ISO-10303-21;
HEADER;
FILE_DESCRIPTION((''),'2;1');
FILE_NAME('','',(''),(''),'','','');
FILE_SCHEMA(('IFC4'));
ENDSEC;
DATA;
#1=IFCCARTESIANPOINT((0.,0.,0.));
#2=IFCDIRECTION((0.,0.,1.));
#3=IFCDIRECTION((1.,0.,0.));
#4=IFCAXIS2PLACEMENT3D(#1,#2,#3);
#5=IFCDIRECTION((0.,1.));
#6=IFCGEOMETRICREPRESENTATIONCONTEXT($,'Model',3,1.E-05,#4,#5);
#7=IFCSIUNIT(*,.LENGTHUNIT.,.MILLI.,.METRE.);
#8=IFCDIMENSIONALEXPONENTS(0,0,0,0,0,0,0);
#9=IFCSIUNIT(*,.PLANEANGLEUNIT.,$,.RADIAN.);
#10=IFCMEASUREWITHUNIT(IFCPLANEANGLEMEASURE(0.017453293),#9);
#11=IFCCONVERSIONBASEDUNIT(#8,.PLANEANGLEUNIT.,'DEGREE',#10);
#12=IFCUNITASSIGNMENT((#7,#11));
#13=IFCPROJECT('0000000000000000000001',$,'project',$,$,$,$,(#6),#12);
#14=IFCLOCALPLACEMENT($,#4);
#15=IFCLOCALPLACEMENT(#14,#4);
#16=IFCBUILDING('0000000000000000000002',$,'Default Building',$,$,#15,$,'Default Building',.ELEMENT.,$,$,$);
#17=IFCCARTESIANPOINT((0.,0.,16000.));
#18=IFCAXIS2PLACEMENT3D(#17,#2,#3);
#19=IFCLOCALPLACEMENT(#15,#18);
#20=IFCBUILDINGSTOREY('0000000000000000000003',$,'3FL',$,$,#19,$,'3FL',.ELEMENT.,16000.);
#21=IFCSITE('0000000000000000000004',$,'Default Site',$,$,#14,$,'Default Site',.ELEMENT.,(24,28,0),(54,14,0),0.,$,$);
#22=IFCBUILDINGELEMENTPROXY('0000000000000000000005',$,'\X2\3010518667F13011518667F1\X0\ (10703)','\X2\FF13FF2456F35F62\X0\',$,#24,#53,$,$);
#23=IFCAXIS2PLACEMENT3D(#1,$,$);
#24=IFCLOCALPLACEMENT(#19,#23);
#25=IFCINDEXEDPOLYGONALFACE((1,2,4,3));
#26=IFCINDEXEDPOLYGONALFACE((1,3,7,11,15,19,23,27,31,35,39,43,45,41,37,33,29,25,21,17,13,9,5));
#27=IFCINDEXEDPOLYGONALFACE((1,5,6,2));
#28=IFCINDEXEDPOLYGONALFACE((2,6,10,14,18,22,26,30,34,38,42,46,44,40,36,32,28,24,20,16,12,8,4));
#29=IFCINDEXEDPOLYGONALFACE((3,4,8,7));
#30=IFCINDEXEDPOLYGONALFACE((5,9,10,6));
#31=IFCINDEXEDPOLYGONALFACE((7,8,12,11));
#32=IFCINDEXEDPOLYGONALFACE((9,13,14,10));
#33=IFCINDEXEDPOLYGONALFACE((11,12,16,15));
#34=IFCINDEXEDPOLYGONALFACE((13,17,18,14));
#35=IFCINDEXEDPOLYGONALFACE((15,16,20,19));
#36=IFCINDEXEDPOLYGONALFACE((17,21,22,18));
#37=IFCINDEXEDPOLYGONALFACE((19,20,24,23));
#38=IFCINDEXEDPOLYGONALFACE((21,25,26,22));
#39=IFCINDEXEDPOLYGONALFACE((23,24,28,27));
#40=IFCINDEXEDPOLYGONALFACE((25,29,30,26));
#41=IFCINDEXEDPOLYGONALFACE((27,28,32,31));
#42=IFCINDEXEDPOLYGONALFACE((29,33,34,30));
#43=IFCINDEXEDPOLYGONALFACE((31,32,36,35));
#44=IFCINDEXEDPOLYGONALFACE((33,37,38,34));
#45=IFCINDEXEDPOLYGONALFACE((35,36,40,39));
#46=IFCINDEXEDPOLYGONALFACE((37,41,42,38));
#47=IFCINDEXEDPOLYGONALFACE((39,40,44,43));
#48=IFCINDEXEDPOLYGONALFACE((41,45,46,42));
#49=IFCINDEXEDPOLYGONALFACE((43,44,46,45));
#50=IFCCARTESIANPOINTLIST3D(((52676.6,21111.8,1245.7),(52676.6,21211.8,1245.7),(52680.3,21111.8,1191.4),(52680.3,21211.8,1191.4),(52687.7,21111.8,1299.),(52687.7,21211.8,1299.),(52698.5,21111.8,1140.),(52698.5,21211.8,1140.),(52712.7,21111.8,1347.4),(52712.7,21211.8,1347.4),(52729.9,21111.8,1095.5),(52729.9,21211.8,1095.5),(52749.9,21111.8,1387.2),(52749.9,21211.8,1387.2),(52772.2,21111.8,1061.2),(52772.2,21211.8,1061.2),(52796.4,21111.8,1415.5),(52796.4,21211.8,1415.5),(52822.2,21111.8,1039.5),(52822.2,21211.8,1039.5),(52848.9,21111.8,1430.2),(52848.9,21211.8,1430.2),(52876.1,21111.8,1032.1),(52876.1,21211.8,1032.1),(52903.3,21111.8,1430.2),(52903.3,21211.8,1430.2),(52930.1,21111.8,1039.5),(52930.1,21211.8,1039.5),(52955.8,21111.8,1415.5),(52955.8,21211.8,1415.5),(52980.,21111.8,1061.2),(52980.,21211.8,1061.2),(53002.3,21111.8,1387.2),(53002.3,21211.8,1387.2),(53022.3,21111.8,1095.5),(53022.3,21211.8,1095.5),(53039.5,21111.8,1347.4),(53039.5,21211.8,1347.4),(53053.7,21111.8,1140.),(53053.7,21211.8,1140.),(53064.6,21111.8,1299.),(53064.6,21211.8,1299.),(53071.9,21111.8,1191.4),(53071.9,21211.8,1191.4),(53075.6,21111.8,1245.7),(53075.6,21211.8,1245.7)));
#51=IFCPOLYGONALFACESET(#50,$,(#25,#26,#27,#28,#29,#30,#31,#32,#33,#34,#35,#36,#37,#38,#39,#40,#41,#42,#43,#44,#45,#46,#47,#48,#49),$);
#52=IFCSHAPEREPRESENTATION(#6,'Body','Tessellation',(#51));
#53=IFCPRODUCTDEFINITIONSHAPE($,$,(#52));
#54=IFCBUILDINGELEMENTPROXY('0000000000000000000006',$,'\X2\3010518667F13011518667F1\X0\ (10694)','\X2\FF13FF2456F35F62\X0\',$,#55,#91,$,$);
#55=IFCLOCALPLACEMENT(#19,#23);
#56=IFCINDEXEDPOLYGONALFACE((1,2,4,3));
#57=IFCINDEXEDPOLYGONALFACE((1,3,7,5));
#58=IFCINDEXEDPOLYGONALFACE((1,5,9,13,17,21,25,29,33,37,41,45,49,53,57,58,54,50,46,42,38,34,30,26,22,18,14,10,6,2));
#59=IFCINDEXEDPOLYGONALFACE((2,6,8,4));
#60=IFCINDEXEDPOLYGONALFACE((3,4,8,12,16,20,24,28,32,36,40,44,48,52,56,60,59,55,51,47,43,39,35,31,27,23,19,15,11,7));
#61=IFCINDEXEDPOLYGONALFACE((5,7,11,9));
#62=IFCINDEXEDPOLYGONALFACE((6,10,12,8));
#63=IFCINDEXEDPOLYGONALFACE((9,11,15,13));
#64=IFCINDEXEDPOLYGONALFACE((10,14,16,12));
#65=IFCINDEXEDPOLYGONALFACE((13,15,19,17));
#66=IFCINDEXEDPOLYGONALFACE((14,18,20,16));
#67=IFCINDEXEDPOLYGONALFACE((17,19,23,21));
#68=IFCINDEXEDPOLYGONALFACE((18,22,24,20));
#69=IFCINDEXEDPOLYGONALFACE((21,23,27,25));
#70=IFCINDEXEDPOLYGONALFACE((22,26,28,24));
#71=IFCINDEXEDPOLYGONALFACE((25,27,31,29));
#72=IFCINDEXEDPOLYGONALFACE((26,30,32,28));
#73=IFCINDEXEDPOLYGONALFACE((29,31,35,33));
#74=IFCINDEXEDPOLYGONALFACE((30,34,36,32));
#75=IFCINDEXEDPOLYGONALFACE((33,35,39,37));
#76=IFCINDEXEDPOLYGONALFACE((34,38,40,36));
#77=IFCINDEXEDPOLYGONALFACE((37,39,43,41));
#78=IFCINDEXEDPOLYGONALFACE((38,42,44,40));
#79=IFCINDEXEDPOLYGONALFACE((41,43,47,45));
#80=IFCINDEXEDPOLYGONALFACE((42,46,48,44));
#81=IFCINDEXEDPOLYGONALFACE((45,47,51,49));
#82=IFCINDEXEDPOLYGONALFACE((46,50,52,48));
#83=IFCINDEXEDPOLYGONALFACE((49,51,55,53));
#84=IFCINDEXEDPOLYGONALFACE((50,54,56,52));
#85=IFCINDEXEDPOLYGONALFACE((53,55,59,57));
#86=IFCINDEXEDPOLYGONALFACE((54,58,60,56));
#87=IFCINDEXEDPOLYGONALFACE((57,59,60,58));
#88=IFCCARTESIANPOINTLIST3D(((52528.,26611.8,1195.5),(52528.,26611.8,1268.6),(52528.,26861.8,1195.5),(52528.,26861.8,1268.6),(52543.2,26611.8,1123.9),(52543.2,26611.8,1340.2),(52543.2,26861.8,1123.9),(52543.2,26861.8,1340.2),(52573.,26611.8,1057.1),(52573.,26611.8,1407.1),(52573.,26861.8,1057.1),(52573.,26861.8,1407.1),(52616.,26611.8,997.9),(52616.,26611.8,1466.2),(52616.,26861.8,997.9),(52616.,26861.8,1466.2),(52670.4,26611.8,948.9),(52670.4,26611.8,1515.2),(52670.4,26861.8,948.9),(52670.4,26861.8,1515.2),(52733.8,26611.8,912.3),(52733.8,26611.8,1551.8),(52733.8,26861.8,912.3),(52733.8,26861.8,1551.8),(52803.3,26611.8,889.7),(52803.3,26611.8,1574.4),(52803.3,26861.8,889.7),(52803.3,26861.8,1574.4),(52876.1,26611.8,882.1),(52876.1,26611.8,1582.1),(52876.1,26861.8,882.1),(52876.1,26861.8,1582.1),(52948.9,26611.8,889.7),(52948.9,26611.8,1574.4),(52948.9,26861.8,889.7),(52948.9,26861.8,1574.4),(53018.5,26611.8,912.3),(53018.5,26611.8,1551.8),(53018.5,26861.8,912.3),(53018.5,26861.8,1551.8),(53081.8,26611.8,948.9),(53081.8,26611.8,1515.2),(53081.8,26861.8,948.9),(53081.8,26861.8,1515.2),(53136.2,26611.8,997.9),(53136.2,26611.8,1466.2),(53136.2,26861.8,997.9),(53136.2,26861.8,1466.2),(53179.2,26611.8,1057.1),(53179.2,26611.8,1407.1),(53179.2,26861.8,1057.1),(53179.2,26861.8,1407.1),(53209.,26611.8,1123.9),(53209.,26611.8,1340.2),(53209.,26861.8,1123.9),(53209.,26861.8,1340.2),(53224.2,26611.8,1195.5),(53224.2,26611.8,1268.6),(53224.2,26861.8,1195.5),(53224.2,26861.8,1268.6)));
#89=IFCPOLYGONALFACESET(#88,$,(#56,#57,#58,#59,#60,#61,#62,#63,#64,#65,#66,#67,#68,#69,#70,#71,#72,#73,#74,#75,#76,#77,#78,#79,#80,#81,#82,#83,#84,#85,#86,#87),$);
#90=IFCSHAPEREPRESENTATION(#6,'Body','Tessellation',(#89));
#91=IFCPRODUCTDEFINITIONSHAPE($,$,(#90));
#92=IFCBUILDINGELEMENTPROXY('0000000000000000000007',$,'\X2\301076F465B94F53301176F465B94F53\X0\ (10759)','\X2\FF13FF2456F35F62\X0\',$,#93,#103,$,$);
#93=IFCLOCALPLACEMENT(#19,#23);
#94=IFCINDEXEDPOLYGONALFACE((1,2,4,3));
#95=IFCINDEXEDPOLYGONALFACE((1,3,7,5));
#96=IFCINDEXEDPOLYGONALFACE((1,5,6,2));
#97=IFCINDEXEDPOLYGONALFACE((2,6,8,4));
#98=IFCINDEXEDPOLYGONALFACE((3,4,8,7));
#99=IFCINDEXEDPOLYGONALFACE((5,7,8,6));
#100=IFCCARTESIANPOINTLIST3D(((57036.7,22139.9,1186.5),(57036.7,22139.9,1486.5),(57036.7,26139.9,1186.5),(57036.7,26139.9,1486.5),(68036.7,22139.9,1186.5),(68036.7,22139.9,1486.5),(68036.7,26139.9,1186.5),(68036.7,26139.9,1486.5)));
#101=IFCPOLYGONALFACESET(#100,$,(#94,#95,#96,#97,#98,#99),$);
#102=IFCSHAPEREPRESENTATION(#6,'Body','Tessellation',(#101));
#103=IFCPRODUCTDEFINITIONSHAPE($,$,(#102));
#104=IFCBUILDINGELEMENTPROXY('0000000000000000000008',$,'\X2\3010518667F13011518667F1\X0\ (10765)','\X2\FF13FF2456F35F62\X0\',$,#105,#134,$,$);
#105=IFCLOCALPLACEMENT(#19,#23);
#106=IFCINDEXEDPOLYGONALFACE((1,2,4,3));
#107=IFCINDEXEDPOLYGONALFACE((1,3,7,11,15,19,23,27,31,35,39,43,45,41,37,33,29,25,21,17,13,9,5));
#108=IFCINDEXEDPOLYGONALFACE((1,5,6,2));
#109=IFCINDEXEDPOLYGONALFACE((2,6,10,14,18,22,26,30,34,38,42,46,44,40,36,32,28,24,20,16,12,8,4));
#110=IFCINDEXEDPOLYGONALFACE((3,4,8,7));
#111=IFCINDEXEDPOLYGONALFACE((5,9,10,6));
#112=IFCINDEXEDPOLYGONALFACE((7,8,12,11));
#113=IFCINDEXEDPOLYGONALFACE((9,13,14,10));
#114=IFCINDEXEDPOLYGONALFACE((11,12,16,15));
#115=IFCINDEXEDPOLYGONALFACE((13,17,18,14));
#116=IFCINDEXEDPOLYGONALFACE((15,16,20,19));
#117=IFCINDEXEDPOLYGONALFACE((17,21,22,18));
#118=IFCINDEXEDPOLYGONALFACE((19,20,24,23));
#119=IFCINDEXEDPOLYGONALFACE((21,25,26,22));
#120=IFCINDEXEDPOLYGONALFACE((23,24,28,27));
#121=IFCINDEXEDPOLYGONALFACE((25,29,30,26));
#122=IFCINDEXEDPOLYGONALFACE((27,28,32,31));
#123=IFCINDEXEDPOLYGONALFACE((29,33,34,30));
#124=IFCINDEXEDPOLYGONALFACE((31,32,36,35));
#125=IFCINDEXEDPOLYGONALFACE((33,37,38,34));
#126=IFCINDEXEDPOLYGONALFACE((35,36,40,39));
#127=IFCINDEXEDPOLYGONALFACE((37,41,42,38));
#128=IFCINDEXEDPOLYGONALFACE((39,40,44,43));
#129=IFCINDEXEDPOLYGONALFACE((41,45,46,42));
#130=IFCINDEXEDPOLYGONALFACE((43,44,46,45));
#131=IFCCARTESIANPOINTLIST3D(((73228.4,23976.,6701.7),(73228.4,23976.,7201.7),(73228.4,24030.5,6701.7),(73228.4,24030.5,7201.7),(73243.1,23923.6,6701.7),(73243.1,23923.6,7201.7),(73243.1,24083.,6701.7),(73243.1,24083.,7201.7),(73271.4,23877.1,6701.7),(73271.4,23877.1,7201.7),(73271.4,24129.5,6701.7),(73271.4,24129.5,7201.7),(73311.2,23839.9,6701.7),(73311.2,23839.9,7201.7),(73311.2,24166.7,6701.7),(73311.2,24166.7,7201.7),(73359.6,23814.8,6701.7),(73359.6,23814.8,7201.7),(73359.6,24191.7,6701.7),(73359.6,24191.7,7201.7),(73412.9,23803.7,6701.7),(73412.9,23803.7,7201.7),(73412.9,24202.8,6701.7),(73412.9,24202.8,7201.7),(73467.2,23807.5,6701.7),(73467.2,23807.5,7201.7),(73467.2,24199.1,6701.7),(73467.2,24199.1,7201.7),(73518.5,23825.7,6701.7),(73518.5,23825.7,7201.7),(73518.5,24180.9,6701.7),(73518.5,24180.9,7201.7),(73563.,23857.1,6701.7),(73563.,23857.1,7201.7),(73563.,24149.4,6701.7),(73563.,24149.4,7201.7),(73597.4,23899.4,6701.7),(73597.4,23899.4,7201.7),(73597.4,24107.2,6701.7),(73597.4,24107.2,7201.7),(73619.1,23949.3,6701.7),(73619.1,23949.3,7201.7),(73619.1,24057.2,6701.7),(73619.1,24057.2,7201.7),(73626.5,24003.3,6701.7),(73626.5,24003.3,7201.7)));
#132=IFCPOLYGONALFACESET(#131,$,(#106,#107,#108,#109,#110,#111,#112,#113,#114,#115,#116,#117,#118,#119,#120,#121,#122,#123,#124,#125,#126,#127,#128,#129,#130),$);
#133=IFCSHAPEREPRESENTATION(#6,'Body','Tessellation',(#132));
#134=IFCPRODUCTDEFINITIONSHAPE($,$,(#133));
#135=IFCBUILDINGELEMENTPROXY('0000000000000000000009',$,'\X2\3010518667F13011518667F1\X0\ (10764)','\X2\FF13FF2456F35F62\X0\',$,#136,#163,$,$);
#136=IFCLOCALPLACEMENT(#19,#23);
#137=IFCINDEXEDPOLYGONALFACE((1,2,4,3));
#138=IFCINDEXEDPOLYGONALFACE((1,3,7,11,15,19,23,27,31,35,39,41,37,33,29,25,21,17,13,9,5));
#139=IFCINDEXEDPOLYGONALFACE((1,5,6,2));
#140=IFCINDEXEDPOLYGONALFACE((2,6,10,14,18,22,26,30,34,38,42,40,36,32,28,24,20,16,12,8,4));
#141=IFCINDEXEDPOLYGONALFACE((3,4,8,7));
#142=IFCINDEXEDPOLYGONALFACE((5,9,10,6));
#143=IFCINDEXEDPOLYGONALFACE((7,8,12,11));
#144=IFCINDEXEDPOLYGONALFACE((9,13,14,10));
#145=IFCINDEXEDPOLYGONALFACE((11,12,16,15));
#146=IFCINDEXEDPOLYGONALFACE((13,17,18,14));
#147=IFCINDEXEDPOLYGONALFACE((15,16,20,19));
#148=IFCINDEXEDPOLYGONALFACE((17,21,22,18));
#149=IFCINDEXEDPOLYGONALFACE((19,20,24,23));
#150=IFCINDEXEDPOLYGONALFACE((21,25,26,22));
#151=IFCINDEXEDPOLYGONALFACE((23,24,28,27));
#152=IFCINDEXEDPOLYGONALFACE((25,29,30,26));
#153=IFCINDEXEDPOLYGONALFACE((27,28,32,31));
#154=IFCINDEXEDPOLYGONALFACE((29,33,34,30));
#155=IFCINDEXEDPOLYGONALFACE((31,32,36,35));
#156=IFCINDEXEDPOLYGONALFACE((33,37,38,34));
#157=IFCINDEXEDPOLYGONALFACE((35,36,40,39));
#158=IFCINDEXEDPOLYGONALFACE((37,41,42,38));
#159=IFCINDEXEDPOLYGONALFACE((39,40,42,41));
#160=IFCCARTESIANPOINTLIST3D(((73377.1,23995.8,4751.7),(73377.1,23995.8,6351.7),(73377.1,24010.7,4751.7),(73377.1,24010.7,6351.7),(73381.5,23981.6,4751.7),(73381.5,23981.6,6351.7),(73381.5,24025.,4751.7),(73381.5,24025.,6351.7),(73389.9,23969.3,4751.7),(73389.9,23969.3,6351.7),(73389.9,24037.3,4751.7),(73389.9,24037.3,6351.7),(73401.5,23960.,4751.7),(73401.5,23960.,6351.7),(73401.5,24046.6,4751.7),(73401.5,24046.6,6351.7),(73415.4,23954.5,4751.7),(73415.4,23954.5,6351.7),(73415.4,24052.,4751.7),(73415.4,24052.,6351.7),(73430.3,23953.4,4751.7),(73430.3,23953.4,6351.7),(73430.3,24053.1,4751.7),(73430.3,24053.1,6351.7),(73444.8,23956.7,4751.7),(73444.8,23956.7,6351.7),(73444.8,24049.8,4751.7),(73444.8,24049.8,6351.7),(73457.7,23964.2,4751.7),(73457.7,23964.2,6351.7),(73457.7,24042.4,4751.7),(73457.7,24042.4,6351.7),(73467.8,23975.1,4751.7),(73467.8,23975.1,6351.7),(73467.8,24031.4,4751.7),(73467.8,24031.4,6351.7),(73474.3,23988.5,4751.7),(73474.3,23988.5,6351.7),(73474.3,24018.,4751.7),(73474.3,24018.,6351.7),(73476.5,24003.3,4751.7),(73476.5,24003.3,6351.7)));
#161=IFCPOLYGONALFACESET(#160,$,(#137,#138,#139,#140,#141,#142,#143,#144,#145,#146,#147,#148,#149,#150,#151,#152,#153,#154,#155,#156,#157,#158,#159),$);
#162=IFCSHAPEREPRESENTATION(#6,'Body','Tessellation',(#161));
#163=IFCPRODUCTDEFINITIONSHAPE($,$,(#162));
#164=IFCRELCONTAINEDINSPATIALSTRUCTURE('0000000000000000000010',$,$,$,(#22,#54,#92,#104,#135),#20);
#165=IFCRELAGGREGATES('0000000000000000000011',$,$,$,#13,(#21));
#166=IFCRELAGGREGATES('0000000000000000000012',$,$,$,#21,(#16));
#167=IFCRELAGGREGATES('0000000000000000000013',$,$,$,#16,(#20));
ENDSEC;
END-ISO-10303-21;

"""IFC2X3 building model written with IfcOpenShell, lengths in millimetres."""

from ifc_helpers import new_model, entity, si_unit, converted_unit, direction, frame, origin_with_axes, origin_2d_with_axis, place, context, project, spatial, rectangle, circle, extrude, source, transform, mapped, element, save


model = new_model("IFC2X3")

# Units and contexts
model_context = context("Model", 3, precision=1e-05, world=origin_with_axes(), true_north=direction((0.0, 1.0)))
ifc_project = project(units=[si_unit("LENGTHUNIT", "METRE", prefix="MILLI"), converted_unit("PLANEANGLEUNIT", "DEGREE", entity("IfcPlaneAngleMeasure", 0.017453293), si_unit("PLANEANGLEUNIT", "RADIAN"), dimensions=[0, 0, 0, 0, 0, 0, 0])], contexts=[model_context])

# Site, building, storey
site_placement = place(None, origin_with_axes())
site = spatial("IfcSite", under=ifc_project, at=site_placement, Name="Default Site", LongName="Default Site", CompositionType="ELEMENT", RefLatitude=(24, 28, 0), RefLongitude=(54, 14, 0), RefElevation=0.0)
building_placement = place(site_placement, origin_with_axes())
building = spatial("IfcBuilding", under=site, at=building_placement, Name="Default Building", LongName="Default Building", CompositionType="ELEMENT")
storey_placement = place(building_placement, frame((0.0, 0.0, 16000.0), z_axis=(0.0, 0.0, 1.0), x_axis=(1.0, 0.0, 0.0)))
storey = spatial("IfcBuildingStorey", under=building, at=storey_placement, Name="3FL", LongName="3FL", CompositionType="ELEMENT", Elevation=16000.0)

# Building element proxies
shared_shape_1 = source(origin_with_axes(), model_context, "Body", "SweptSolid", [
    extrude(circle(Radius=200.0, at=origin_2d_with_axis()), frame((0.0, 0.0, 0.0), z_axis=(0.0, 0.0, 1.0), x_axis=(1.0, 0.0, 0.0)), (0.0, 0.0, 1.0), 100.0),
])
proxy_1_placement = place(storey_placement, frame((52876.1, 21111.8, 1232.1), z_axis=(0.0, 1.0, 0.0), x_axis=(0.0, 0.0, -1.0)))
element("IfcBuildingElementProxy", 1, at=proxy_1_placement, inside=storey, Name="【円柱】円柱 (10703)", Description="３Ｄ図形", context=model_context, shape_type="MappedRepresentation", body=[
    mapped(shared_shape_1, transform((0.0, 0.0, 0.0))),
])
shared_shape_2 = source(origin_with_axes(), model_context, "Body", "SweptSolid", [
    extrude(circle(Radius=350.0, at=origin_2d_with_axis()), frame((0.0, 0.0, 0.0), z_axis=(0.0, 0.0, 1.0), x_axis=(1.0, 0.0, 0.0)), (0.0, 0.0, 1.0), 250.0),
])
proxy_2_placement = place(storey_placement, frame((52876.1, 26611.8, 1232.1), z_axis=(0.0, 1.0, 0.0), x_axis=(0.0, 0.0, -1.0)))
element("IfcBuildingElementProxy", 2, at=proxy_2_placement, inside=storey, Name="【円柱】円柱 (10694)", Description="３Ｄ図形", context=model_context, shape_type="MappedRepresentation", body=[
    mapped(shared_shape_2, transform((0.0, 0.0, 0.0))),
])
shared_shape_3 = source(origin_with_axes(), model_context, "Body", "SweptSolid", [
    extrude(rectangle(XDim=11000.0, YDim=4000.0, at=origin_2d_with_axis()), origin_with_axes(), (0.0, 0.0, 1.0), 300.0),
])
proxy_3_placement = place(storey_placement, frame((62536.7, 24139.9, 1186.5), z_axis=(0.0, 0.0, 1.0), x_axis=(1.0, 0.0, 0.0)))
element("IfcBuildingElementProxy", 3, at=proxy_3_placement, inside=storey, Name="【直方体】直方体 (10759)", Description="３Ｄ図形", context=model_context, shape_type="MappedRepresentation", body=[
    mapped(shared_shape_3, transform((0.0, 0.0, 0.0))),
])
shared_shape_4 = source(origin_with_axes(), model_context, "Body", "SweptSolid", [
    extrude(circle(Radius=200.0, at=origin_2d_with_axis()), origin_with_axes(), (0.0, 0.0, 1.0), 500.0),
])
proxy_4_placement = place(storey_placement, frame((73426.5, 24003.3, 6701.7), z_axis=(0.0, 0.0, 1.0), x_axis=(1.0, 0.0, 0.0)))
element("IfcBuildingElementProxy", 4, at=proxy_4_placement, inside=storey, Name="【円柱】円柱 (10765)", Description="３Ｄ図形", context=model_context, shape_type="MappedRepresentation", body=[
    mapped(shared_shape_4, transform((0.0, 0.0, 0.0))),
])
shared_shape_5 = source(origin_with_axes(), model_context, "Body", "SweptSolid", [
    extrude(circle(Radius=50.0, at=origin_2d_with_axis()), origin_with_axes(), (0.0, 0.0, 1.0), 1600.0),
])
proxy_5_placement = place(storey_placement, frame((73426.5, 24003.3, 4751.7), z_axis=(0.0, 0.0, 1.0), x_axis=(1.0, 0.0, 0.0)))
element("IfcBuildingElementProxy", 5, at=proxy_5_placement, inside=storey, Name="【円柱】円柱 (10764)", Description="３Ｄ図形", context=model_context, shape_type="MappedRepresentation", body=[
    mapped(shared_shape_5, transform((0.0, 0.0, 0.0))),
])

save(model, "model.ifc")
